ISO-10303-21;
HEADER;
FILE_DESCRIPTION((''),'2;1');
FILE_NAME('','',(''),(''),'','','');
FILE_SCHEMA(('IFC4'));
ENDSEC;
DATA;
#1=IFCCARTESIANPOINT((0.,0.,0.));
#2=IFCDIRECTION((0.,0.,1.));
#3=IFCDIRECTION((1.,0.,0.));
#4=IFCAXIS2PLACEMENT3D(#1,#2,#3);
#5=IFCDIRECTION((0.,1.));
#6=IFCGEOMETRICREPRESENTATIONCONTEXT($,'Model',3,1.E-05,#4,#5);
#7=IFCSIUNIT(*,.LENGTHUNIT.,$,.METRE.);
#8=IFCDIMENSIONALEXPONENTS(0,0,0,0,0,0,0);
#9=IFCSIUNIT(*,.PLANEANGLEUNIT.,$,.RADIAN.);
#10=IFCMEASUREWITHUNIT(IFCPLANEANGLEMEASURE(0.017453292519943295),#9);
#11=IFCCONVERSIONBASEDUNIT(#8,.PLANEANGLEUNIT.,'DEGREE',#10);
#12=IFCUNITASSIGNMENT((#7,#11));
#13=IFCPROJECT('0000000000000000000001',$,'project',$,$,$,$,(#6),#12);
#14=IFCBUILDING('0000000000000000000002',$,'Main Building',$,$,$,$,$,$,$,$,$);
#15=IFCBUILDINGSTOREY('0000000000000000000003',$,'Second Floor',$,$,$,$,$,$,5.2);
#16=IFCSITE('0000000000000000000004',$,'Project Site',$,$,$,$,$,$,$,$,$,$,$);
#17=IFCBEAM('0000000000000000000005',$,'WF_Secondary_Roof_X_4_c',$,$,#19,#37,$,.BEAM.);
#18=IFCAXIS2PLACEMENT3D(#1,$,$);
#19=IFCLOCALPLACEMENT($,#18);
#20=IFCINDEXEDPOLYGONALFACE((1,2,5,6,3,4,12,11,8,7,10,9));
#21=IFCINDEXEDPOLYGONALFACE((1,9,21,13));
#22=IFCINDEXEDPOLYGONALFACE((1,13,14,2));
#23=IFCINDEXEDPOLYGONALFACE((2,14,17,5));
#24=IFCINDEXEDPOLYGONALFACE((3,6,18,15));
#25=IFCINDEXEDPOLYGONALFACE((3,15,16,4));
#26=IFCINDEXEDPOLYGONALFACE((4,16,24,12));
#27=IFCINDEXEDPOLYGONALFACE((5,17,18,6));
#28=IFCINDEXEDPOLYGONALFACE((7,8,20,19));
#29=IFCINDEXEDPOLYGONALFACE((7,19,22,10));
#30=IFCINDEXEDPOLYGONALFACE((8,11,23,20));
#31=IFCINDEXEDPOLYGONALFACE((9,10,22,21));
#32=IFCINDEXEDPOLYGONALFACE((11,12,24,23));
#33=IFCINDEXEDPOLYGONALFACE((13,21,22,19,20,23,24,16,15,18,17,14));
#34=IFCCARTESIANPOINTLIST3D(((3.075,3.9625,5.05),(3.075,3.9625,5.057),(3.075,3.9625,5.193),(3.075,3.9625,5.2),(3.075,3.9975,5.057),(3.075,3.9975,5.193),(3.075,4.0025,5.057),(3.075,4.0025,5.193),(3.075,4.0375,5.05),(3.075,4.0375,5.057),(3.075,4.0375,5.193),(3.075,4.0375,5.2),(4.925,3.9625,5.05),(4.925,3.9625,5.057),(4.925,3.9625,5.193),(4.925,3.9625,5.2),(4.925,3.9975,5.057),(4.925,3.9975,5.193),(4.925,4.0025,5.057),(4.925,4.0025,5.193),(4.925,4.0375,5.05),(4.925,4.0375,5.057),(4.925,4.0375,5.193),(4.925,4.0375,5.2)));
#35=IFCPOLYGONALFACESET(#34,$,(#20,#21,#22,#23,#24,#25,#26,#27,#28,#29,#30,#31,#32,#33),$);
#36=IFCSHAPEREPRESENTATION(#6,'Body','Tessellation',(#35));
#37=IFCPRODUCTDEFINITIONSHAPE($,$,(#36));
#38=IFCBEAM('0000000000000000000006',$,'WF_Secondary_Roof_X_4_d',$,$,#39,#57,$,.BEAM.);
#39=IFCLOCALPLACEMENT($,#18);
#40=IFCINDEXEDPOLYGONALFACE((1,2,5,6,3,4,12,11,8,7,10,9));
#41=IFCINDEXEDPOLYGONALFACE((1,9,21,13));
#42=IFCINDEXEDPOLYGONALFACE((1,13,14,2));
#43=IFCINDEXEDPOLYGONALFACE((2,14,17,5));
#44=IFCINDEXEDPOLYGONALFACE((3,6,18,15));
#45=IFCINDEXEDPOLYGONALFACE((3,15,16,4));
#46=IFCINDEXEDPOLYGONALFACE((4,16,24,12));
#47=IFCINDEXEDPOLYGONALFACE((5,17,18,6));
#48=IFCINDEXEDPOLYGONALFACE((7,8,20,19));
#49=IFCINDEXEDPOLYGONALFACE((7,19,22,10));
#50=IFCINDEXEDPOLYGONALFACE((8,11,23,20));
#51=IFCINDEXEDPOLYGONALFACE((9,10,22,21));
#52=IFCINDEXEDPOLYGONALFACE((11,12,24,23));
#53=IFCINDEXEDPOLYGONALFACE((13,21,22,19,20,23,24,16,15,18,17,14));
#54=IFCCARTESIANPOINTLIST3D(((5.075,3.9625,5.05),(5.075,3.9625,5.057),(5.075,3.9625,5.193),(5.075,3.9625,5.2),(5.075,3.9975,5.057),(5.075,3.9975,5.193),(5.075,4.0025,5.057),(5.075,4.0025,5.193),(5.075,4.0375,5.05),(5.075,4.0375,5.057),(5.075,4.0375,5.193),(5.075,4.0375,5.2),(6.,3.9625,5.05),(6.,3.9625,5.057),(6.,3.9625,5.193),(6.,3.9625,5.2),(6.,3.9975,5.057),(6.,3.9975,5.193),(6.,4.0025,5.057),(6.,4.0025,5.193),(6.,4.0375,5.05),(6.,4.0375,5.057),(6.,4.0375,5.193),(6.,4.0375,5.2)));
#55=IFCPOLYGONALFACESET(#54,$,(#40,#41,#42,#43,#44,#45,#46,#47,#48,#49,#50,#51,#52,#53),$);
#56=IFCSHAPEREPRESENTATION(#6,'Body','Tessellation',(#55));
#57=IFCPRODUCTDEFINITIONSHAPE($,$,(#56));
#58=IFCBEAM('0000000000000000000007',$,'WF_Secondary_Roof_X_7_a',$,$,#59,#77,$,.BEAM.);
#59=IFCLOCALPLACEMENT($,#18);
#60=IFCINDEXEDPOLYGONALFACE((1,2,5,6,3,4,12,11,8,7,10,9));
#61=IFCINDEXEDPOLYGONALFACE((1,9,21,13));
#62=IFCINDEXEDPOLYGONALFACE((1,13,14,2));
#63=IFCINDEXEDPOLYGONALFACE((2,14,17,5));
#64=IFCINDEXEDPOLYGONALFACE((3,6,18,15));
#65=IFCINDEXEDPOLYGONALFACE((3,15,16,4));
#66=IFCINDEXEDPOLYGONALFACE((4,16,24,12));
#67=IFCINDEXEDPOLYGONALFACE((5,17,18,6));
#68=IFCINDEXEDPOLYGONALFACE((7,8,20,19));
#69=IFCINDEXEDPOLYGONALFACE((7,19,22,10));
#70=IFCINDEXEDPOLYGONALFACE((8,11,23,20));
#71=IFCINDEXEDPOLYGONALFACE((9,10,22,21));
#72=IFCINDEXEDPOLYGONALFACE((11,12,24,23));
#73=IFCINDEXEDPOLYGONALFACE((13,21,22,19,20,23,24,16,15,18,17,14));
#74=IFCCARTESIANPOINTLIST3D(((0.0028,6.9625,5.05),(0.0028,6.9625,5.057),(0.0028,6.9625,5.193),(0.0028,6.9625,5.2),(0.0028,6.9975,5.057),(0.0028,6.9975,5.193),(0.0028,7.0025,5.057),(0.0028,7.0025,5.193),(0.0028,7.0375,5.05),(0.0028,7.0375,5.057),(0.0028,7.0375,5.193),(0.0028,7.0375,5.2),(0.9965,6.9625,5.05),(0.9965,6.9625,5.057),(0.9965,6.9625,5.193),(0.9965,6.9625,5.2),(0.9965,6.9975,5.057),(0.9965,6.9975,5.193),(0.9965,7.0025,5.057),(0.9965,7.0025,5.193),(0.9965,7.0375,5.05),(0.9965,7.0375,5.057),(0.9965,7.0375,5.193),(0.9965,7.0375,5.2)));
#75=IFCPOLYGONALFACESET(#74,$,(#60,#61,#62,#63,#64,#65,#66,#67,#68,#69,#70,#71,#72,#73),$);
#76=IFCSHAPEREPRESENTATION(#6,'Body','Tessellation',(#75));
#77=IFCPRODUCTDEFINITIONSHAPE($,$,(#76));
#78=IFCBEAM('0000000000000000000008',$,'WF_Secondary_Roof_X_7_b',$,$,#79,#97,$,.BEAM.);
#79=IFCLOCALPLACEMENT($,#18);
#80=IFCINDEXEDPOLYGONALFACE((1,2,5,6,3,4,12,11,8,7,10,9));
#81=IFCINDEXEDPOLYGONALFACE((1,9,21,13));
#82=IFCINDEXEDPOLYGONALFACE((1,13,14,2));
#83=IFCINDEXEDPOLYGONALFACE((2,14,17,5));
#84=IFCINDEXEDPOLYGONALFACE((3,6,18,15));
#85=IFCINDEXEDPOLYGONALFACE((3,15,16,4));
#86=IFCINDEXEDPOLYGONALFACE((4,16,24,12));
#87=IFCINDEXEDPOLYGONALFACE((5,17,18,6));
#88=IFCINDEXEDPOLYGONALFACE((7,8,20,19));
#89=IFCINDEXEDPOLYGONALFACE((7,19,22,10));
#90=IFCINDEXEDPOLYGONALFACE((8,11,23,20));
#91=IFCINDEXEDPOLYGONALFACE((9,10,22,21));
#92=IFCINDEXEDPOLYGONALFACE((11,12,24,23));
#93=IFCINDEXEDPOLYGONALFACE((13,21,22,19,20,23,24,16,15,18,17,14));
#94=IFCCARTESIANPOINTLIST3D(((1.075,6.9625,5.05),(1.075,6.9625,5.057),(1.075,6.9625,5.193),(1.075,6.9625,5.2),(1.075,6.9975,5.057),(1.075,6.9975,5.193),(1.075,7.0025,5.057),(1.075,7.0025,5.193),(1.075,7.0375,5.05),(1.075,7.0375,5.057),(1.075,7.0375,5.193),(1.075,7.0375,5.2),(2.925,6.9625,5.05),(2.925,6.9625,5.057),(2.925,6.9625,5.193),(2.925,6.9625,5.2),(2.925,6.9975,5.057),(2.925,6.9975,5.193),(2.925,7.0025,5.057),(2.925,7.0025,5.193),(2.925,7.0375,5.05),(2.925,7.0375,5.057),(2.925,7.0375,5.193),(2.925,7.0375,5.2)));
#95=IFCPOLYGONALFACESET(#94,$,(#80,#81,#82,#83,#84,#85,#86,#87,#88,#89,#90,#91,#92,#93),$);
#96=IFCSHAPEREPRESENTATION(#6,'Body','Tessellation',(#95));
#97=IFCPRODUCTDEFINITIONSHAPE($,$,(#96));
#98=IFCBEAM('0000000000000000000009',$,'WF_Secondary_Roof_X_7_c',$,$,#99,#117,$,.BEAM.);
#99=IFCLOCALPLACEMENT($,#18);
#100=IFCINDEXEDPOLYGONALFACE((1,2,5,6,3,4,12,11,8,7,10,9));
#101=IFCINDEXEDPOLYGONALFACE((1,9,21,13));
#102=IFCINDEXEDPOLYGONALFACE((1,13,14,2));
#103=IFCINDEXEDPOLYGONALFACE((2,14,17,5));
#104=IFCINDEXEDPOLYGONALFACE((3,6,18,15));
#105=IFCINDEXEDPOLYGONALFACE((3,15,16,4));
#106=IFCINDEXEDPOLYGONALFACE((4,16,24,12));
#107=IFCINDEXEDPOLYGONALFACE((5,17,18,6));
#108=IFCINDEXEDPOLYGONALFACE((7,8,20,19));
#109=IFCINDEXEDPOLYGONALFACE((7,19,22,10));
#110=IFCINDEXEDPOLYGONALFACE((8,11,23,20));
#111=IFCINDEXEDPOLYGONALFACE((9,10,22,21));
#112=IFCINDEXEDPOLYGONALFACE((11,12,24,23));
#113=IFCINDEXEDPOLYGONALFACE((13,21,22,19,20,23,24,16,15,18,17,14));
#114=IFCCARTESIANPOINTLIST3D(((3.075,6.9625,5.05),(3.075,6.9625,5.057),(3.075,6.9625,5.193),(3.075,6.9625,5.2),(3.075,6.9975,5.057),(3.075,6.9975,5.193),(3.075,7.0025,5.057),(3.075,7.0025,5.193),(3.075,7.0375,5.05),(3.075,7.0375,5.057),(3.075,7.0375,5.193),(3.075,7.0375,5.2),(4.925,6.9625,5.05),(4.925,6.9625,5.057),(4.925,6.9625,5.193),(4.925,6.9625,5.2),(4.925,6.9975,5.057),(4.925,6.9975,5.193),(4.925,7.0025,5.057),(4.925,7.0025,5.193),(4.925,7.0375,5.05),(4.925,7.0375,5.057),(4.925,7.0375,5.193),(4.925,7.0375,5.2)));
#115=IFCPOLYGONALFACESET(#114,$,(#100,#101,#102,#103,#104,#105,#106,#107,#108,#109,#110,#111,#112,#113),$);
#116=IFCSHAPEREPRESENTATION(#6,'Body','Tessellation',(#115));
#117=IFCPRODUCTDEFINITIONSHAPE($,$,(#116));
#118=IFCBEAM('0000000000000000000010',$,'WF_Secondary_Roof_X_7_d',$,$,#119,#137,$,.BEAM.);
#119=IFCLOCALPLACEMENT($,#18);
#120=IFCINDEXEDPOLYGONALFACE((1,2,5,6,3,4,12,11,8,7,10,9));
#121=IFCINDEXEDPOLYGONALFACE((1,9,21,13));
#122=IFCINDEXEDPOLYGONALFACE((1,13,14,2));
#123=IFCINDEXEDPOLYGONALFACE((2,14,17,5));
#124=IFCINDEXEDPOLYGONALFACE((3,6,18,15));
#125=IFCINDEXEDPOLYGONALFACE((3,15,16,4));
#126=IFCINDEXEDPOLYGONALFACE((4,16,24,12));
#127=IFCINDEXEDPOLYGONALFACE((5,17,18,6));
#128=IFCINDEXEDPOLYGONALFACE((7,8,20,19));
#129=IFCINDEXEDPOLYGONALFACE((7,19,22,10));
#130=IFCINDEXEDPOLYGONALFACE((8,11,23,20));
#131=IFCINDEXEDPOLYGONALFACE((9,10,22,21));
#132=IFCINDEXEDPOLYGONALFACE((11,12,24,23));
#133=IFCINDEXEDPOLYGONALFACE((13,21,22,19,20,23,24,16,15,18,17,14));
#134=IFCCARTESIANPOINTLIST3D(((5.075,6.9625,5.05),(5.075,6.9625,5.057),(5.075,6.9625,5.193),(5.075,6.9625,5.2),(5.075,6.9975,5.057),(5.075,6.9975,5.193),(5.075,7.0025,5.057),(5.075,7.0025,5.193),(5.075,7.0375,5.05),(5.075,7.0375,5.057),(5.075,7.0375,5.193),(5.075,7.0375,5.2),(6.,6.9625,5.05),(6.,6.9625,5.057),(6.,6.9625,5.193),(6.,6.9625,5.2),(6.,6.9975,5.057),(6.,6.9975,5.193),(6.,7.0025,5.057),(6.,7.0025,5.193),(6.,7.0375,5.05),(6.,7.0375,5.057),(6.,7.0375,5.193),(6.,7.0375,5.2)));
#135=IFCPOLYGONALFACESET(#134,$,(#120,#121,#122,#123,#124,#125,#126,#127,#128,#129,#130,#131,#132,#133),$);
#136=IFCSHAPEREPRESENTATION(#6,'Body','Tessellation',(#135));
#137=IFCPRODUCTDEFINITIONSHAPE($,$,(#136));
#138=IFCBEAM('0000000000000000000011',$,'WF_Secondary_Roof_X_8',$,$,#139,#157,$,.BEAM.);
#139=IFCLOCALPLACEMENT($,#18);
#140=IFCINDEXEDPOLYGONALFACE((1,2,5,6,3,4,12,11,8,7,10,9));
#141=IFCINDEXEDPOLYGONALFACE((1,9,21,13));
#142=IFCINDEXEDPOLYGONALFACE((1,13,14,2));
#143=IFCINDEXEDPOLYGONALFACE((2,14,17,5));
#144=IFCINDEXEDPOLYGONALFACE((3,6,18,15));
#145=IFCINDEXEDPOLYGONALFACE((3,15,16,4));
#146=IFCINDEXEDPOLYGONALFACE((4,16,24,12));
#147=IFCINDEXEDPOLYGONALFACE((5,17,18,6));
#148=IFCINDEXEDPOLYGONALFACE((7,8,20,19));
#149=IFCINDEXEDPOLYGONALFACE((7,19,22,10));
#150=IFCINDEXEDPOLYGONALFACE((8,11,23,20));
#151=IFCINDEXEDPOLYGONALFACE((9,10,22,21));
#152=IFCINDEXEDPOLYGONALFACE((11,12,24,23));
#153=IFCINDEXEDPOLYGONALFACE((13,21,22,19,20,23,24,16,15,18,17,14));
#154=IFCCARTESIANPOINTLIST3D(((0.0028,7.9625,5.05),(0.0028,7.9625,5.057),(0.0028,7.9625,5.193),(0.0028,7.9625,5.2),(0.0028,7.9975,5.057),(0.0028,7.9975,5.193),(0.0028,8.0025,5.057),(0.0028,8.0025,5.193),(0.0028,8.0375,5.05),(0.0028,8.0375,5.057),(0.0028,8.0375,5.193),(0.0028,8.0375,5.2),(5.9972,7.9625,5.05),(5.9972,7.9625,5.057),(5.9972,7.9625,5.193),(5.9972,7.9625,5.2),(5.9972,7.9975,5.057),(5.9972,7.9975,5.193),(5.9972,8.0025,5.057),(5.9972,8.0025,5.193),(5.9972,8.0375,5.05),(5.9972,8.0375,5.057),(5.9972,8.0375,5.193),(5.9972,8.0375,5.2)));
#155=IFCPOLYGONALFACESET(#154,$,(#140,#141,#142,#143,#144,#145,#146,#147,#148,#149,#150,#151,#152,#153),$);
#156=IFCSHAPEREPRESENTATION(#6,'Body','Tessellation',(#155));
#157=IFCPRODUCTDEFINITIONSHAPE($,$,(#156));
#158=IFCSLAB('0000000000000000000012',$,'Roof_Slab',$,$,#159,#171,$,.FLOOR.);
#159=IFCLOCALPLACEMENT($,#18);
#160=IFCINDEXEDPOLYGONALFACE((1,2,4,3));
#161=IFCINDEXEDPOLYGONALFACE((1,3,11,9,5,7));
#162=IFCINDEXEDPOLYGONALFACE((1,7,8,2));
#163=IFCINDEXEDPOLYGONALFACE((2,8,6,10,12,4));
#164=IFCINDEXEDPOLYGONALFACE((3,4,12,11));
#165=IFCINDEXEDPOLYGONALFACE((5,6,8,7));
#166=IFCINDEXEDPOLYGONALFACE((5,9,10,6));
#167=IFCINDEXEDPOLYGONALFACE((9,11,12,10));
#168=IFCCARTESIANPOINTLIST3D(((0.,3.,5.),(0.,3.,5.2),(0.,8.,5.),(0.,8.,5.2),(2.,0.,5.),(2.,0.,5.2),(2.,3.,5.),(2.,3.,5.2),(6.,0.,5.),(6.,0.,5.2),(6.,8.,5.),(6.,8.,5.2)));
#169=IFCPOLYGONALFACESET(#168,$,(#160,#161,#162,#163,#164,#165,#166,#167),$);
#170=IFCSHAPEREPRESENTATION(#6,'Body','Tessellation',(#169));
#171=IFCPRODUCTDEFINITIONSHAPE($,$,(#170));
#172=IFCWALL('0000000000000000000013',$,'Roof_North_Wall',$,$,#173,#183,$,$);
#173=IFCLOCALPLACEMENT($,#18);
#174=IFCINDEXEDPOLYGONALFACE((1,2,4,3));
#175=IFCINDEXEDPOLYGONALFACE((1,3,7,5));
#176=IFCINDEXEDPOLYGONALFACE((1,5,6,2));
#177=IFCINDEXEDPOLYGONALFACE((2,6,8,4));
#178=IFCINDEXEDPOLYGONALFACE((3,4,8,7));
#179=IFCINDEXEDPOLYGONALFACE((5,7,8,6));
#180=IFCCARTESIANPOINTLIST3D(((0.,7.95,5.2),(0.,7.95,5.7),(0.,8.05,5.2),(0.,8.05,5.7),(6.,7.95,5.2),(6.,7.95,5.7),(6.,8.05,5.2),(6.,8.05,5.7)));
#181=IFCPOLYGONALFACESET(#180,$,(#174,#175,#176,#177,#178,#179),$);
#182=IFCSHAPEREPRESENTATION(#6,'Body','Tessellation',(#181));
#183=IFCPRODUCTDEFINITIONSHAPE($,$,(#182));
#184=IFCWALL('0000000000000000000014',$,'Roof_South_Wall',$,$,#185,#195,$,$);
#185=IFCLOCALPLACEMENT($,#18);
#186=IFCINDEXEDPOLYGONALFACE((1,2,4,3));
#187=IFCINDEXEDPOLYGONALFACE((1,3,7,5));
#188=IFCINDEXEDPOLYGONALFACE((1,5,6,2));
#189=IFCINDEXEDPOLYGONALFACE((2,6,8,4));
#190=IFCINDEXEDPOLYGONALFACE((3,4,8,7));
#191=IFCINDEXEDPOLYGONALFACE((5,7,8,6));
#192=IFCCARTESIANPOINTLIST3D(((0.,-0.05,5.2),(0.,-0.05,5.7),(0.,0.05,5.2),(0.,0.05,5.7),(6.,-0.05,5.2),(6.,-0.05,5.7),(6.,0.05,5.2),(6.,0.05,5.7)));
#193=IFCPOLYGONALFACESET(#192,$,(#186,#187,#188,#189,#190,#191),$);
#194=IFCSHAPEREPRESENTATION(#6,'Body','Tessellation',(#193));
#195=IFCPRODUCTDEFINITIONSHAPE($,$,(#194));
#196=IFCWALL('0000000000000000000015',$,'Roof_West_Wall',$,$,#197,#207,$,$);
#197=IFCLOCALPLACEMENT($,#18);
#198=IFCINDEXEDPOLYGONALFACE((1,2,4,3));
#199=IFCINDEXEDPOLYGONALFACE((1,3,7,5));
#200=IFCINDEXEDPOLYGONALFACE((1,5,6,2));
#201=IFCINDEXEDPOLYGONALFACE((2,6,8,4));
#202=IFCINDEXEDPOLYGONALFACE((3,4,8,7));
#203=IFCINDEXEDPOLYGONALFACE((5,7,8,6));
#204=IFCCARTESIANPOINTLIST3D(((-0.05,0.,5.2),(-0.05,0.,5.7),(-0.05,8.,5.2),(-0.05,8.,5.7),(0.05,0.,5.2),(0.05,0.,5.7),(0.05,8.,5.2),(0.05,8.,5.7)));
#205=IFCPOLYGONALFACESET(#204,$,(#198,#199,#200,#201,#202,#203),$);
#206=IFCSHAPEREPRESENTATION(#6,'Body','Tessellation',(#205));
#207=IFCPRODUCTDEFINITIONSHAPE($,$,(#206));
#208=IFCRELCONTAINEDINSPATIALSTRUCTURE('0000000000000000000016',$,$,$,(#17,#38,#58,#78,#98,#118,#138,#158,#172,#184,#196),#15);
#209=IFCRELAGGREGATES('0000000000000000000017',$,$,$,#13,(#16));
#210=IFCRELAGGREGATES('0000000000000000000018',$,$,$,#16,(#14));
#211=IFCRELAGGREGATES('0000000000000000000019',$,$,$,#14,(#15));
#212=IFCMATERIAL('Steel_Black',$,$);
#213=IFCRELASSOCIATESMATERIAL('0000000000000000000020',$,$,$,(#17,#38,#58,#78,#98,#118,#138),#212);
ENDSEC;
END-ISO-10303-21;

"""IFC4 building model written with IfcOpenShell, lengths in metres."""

from ifc_helpers import new_model, entity, si_unit, converted_unit, direction, frame, frame_2d, origin, origin_with_axes, place, context, project, spatial, polyline, rectangle, i_section, outline, extrude, material, element, save


model = new_model("IFC4")

# Units and contexts
model_context = context("Model", 3, precision=1e-05, world=origin_with_axes(), true_north=direction((0.0, 1.0)))
ifc_project = project(units=[si_unit("LENGTHUNIT", "METRE"), converted_unit("PLANEANGLEUNIT", "DEGREE", entity("IfcPlaneAngleMeasure", 0.017453292519943295), si_unit("PLANEANGLEUNIT", "RADIAN"), dimensions=[0, 0, 0, 0, 0, 0, 0])], contexts=[model_context])

# Site, building, storey
site = spatial("IfcSite", under=ifc_project, Name="Project Site")
building = spatial("IfcBuilding", under=site, Name="Main Building")
storey = spatial("IfcBuildingStorey", under=building, Name="Second Floor", Elevation=5.2)

# Beams
ifc_material = material(Name="Steel_Black")
for number, where, z_axis, x_axis, name in (
    (1, (3.075, 4.0, 5.05), (0.0, 0.0, 1.0), (1.0, 0.0, 0.0), "WF_Secondary_Roof_X_4_c"),
):
    element("IfcBeam", number, at=place(None, frame(where, z_axis=z_axis, x_axis=x_axis)), inside=storey, material=ifc_material, Name=name, PredefinedType="BEAM", context=model_context, shape_type="SweptSolid", body=[
        extrude(i_section(OverallWidth=0.075, OverallDepth=0.15, WebThickness=0.005, FlangeThickness=0.007, at=frame_2d((0.0, 0.075))), frame((0.0, 0.0, 0.0), z_axis=(1.0, 0.0, 0.0), x_axis=(0.0, 1.0, 0.0)), (0.0, 0.0, 1.0), 1.85),
    ])
beam_1_placement = place(None, frame((5.075, 4.0, 5.05), z_axis=(0.0, 0.0, 1.0), x_axis=(1.0, 0.0, 0.0)))
element("IfcBeam", 2, at=beam_1_placement, inside=storey, material=ifc_material, Name="WF_Secondary_Roof_X_4_d", PredefinedType="BEAM", context=model_context, shape_type="SweptSolid", body=[
    extrude(i_section(OverallWidth=0.075, OverallDepth=0.15, WebThickness=0.005, FlangeThickness=0.007, at=frame_2d((0.0, 0.075))), frame((0.0, 0.0, 0.0), z_axis=(1.0, 0.0, 0.0), x_axis=(0.0, 1.0, 0.0)), (0.0, 0.0, 1.0), 0.925),
])
beam_2_placement = place(None, frame((0.0027, 7.0, 5.05), z_axis=(0.0, 0.0, 1.0), x_axis=(1.0, 0.0, 0.0)))
element("IfcBeam", 3, at=beam_2_placement, inside=storey, material=ifc_material, Name="WF_Secondary_Roof_X_7_a", PredefinedType="BEAM", context=model_context, shape_type="SweptSolid", body=[
    extrude(i_section(OverallWidth=0.075, OverallDepth=0.15, WebThickness=0.005, FlangeThickness=0.007, at=frame_2d((0.0, 0.075))), frame((0.0, 0.0, 0.0), z_axis=(1.0, 0.0, 0.0), x_axis=(0.0, 1.0, 0.0)), (0.0, 0.0, 1.0), 0.9938),
])
for number, where, z_axis, x_axis, name in (
    (4, (1.075, 7.0, 5.05), (0.0, 0.0, 1.0), (1.0, 0.0, 0.0), "WF_Secondary_Roof_X_7_b"),
    (5, (3.075, 7.0, 5.05), (0.0, 0.0, 1.0), (1.0, 0.0, 0.0), "WF_Secondary_Roof_X_7_c"),
):
    element("IfcBeam", number, at=place(None, frame(where, z_axis=z_axis, x_axis=x_axis)), inside=storey, material=ifc_material, Name=name, PredefinedType="BEAM", context=model_context, shape_type="SweptSolid", body=[
        extrude(i_section(OverallWidth=0.075, OverallDepth=0.15, WebThickness=0.005, FlangeThickness=0.007, at=frame_2d((0.0, 0.075))), frame((0.0, 0.0, 0.0), z_axis=(1.0, 0.0, 0.0), x_axis=(0.0, 1.0, 0.0)), (0.0, 0.0, 1.0), 1.85),
    ])
beam_3_placement = place(None, frame((5.075, 7.0, 5.05), z_axis=(0.0, 0.0, 1.0), x_axis=(1.0, 0.0, 0.0)))
element("IfcBeam", 6, at=beam_3_placement, inside=storey, material=ifc_material, Name="WF_Secondary_Roof_X_7_d", PredefinedType="BEAM", context=model_context, shape_type="SweptSolid", body=[
    extrude(i_section(OverallWidth=0.075, OverallDepth=0.15, WebThickness=0.005, FlangeThickness=0.007, at=frame_2d((0.0, 0.075))), frame((0.0, 0.0, 0.0), z_axis=(1.0, 0.0, 0.0), x_axis=(0.0, 1.0, 0.0)), (0.0, 0.0, 1.0), 0.925),
])
beam_4_placement = place(None, frame((0.0027, 8.0, 5.05), z_axis=(0.0, 0.0, 1.0), x_axis=(1.0, 0.0, 0.0)))
element("IfcBeam", 7, at=beam_4_placement, inside=storey, material=ifc_material, Name="WF_Secondary_Roof_X_8", PredefinedType="BEAM", context=model_context, shape_type="SweptSolid", body=[
    extrude(i_section(OverallWidth=0.075, OverallDepth=0.15, WebThickness=0.005, FlangeThickness=0.007, at=frame_2d((0.0, 0.075))), frame((0.0, 0.0, 0.0), z_axis=(1.0, 0.0, 0.0), x_axis=(0.0, 1.0, 0.0)), (0.0, 0.0, 1.0), 5.9945),
])

# Slab
slab_placement = place(None, frame((0.0, 0.0, 5.0), z_axis=(0.0, 0.0, 1.0), x_axis=(1.0, 0.0, 0.0)))
element("IfcSlab", 8, at=slab_placement, inside=storey, Name="Roof_Slab", PredefinedType="FLOOR", context=model_context, shape_type="SweptSolid", body=[
    extrude(outline(polyline([(0.0, 3.0), (2.0, 3.0), (2.0, 0.0), (6.0, 0.0), (6.0, 8.0), (0.0, 8.0), (0.0, 3.0)])), origin(), (0.0, 0.0, 1.0), 0.2),
])

# Walls
for number, where, z_axis, x_axis, name in (
    (9, (0.0, 8.0, 5.2), (0.0, 0.0, 1.0), (1.0, 0.0, 0.0), "Roof_North_Wall"),
    (10, (0.0, 0.0, 5.2), (0.0, 0.0, 1.0), (1.0, 0.0, 0.0), "Roof_South_Wall"),
):
    element("IfcWall", number, at=place(None, frame(where, z_axis=z_axis, x_axis=x_axis)), inside=storey, Name=name, context=model_context, shape_type="SweptSolid", body=[
        extrude(rectangle(XDim=6.0, YDim=0.1, at=frame_2d((3.0, 0.0))), origin(), (0.0, 0.0, 1.0), 0.5),
    ])
for number, where, z_axis, x_axis, name in (
    (11, (0.0, 0.0, 5.2), (0.0, 0.0, 1.0), (0.0, 1.0, 0.0), "Roof_West_Wall"),
):
    element("IfcWall", number, at=place(None, frame(where, z_axis=z_axis, x_axis=x_axis)), inside=storey, Name=name, context=model_context, shape_type="SweptSolid", body=[
        extrude(rectangle(XDim=8.0, YDim=0.1, at=frame_2d((4.0, 0.0))), origin(), (0.0, 0.0, 1.0), 0.5),
    ])

save(model, "model.ifc")
